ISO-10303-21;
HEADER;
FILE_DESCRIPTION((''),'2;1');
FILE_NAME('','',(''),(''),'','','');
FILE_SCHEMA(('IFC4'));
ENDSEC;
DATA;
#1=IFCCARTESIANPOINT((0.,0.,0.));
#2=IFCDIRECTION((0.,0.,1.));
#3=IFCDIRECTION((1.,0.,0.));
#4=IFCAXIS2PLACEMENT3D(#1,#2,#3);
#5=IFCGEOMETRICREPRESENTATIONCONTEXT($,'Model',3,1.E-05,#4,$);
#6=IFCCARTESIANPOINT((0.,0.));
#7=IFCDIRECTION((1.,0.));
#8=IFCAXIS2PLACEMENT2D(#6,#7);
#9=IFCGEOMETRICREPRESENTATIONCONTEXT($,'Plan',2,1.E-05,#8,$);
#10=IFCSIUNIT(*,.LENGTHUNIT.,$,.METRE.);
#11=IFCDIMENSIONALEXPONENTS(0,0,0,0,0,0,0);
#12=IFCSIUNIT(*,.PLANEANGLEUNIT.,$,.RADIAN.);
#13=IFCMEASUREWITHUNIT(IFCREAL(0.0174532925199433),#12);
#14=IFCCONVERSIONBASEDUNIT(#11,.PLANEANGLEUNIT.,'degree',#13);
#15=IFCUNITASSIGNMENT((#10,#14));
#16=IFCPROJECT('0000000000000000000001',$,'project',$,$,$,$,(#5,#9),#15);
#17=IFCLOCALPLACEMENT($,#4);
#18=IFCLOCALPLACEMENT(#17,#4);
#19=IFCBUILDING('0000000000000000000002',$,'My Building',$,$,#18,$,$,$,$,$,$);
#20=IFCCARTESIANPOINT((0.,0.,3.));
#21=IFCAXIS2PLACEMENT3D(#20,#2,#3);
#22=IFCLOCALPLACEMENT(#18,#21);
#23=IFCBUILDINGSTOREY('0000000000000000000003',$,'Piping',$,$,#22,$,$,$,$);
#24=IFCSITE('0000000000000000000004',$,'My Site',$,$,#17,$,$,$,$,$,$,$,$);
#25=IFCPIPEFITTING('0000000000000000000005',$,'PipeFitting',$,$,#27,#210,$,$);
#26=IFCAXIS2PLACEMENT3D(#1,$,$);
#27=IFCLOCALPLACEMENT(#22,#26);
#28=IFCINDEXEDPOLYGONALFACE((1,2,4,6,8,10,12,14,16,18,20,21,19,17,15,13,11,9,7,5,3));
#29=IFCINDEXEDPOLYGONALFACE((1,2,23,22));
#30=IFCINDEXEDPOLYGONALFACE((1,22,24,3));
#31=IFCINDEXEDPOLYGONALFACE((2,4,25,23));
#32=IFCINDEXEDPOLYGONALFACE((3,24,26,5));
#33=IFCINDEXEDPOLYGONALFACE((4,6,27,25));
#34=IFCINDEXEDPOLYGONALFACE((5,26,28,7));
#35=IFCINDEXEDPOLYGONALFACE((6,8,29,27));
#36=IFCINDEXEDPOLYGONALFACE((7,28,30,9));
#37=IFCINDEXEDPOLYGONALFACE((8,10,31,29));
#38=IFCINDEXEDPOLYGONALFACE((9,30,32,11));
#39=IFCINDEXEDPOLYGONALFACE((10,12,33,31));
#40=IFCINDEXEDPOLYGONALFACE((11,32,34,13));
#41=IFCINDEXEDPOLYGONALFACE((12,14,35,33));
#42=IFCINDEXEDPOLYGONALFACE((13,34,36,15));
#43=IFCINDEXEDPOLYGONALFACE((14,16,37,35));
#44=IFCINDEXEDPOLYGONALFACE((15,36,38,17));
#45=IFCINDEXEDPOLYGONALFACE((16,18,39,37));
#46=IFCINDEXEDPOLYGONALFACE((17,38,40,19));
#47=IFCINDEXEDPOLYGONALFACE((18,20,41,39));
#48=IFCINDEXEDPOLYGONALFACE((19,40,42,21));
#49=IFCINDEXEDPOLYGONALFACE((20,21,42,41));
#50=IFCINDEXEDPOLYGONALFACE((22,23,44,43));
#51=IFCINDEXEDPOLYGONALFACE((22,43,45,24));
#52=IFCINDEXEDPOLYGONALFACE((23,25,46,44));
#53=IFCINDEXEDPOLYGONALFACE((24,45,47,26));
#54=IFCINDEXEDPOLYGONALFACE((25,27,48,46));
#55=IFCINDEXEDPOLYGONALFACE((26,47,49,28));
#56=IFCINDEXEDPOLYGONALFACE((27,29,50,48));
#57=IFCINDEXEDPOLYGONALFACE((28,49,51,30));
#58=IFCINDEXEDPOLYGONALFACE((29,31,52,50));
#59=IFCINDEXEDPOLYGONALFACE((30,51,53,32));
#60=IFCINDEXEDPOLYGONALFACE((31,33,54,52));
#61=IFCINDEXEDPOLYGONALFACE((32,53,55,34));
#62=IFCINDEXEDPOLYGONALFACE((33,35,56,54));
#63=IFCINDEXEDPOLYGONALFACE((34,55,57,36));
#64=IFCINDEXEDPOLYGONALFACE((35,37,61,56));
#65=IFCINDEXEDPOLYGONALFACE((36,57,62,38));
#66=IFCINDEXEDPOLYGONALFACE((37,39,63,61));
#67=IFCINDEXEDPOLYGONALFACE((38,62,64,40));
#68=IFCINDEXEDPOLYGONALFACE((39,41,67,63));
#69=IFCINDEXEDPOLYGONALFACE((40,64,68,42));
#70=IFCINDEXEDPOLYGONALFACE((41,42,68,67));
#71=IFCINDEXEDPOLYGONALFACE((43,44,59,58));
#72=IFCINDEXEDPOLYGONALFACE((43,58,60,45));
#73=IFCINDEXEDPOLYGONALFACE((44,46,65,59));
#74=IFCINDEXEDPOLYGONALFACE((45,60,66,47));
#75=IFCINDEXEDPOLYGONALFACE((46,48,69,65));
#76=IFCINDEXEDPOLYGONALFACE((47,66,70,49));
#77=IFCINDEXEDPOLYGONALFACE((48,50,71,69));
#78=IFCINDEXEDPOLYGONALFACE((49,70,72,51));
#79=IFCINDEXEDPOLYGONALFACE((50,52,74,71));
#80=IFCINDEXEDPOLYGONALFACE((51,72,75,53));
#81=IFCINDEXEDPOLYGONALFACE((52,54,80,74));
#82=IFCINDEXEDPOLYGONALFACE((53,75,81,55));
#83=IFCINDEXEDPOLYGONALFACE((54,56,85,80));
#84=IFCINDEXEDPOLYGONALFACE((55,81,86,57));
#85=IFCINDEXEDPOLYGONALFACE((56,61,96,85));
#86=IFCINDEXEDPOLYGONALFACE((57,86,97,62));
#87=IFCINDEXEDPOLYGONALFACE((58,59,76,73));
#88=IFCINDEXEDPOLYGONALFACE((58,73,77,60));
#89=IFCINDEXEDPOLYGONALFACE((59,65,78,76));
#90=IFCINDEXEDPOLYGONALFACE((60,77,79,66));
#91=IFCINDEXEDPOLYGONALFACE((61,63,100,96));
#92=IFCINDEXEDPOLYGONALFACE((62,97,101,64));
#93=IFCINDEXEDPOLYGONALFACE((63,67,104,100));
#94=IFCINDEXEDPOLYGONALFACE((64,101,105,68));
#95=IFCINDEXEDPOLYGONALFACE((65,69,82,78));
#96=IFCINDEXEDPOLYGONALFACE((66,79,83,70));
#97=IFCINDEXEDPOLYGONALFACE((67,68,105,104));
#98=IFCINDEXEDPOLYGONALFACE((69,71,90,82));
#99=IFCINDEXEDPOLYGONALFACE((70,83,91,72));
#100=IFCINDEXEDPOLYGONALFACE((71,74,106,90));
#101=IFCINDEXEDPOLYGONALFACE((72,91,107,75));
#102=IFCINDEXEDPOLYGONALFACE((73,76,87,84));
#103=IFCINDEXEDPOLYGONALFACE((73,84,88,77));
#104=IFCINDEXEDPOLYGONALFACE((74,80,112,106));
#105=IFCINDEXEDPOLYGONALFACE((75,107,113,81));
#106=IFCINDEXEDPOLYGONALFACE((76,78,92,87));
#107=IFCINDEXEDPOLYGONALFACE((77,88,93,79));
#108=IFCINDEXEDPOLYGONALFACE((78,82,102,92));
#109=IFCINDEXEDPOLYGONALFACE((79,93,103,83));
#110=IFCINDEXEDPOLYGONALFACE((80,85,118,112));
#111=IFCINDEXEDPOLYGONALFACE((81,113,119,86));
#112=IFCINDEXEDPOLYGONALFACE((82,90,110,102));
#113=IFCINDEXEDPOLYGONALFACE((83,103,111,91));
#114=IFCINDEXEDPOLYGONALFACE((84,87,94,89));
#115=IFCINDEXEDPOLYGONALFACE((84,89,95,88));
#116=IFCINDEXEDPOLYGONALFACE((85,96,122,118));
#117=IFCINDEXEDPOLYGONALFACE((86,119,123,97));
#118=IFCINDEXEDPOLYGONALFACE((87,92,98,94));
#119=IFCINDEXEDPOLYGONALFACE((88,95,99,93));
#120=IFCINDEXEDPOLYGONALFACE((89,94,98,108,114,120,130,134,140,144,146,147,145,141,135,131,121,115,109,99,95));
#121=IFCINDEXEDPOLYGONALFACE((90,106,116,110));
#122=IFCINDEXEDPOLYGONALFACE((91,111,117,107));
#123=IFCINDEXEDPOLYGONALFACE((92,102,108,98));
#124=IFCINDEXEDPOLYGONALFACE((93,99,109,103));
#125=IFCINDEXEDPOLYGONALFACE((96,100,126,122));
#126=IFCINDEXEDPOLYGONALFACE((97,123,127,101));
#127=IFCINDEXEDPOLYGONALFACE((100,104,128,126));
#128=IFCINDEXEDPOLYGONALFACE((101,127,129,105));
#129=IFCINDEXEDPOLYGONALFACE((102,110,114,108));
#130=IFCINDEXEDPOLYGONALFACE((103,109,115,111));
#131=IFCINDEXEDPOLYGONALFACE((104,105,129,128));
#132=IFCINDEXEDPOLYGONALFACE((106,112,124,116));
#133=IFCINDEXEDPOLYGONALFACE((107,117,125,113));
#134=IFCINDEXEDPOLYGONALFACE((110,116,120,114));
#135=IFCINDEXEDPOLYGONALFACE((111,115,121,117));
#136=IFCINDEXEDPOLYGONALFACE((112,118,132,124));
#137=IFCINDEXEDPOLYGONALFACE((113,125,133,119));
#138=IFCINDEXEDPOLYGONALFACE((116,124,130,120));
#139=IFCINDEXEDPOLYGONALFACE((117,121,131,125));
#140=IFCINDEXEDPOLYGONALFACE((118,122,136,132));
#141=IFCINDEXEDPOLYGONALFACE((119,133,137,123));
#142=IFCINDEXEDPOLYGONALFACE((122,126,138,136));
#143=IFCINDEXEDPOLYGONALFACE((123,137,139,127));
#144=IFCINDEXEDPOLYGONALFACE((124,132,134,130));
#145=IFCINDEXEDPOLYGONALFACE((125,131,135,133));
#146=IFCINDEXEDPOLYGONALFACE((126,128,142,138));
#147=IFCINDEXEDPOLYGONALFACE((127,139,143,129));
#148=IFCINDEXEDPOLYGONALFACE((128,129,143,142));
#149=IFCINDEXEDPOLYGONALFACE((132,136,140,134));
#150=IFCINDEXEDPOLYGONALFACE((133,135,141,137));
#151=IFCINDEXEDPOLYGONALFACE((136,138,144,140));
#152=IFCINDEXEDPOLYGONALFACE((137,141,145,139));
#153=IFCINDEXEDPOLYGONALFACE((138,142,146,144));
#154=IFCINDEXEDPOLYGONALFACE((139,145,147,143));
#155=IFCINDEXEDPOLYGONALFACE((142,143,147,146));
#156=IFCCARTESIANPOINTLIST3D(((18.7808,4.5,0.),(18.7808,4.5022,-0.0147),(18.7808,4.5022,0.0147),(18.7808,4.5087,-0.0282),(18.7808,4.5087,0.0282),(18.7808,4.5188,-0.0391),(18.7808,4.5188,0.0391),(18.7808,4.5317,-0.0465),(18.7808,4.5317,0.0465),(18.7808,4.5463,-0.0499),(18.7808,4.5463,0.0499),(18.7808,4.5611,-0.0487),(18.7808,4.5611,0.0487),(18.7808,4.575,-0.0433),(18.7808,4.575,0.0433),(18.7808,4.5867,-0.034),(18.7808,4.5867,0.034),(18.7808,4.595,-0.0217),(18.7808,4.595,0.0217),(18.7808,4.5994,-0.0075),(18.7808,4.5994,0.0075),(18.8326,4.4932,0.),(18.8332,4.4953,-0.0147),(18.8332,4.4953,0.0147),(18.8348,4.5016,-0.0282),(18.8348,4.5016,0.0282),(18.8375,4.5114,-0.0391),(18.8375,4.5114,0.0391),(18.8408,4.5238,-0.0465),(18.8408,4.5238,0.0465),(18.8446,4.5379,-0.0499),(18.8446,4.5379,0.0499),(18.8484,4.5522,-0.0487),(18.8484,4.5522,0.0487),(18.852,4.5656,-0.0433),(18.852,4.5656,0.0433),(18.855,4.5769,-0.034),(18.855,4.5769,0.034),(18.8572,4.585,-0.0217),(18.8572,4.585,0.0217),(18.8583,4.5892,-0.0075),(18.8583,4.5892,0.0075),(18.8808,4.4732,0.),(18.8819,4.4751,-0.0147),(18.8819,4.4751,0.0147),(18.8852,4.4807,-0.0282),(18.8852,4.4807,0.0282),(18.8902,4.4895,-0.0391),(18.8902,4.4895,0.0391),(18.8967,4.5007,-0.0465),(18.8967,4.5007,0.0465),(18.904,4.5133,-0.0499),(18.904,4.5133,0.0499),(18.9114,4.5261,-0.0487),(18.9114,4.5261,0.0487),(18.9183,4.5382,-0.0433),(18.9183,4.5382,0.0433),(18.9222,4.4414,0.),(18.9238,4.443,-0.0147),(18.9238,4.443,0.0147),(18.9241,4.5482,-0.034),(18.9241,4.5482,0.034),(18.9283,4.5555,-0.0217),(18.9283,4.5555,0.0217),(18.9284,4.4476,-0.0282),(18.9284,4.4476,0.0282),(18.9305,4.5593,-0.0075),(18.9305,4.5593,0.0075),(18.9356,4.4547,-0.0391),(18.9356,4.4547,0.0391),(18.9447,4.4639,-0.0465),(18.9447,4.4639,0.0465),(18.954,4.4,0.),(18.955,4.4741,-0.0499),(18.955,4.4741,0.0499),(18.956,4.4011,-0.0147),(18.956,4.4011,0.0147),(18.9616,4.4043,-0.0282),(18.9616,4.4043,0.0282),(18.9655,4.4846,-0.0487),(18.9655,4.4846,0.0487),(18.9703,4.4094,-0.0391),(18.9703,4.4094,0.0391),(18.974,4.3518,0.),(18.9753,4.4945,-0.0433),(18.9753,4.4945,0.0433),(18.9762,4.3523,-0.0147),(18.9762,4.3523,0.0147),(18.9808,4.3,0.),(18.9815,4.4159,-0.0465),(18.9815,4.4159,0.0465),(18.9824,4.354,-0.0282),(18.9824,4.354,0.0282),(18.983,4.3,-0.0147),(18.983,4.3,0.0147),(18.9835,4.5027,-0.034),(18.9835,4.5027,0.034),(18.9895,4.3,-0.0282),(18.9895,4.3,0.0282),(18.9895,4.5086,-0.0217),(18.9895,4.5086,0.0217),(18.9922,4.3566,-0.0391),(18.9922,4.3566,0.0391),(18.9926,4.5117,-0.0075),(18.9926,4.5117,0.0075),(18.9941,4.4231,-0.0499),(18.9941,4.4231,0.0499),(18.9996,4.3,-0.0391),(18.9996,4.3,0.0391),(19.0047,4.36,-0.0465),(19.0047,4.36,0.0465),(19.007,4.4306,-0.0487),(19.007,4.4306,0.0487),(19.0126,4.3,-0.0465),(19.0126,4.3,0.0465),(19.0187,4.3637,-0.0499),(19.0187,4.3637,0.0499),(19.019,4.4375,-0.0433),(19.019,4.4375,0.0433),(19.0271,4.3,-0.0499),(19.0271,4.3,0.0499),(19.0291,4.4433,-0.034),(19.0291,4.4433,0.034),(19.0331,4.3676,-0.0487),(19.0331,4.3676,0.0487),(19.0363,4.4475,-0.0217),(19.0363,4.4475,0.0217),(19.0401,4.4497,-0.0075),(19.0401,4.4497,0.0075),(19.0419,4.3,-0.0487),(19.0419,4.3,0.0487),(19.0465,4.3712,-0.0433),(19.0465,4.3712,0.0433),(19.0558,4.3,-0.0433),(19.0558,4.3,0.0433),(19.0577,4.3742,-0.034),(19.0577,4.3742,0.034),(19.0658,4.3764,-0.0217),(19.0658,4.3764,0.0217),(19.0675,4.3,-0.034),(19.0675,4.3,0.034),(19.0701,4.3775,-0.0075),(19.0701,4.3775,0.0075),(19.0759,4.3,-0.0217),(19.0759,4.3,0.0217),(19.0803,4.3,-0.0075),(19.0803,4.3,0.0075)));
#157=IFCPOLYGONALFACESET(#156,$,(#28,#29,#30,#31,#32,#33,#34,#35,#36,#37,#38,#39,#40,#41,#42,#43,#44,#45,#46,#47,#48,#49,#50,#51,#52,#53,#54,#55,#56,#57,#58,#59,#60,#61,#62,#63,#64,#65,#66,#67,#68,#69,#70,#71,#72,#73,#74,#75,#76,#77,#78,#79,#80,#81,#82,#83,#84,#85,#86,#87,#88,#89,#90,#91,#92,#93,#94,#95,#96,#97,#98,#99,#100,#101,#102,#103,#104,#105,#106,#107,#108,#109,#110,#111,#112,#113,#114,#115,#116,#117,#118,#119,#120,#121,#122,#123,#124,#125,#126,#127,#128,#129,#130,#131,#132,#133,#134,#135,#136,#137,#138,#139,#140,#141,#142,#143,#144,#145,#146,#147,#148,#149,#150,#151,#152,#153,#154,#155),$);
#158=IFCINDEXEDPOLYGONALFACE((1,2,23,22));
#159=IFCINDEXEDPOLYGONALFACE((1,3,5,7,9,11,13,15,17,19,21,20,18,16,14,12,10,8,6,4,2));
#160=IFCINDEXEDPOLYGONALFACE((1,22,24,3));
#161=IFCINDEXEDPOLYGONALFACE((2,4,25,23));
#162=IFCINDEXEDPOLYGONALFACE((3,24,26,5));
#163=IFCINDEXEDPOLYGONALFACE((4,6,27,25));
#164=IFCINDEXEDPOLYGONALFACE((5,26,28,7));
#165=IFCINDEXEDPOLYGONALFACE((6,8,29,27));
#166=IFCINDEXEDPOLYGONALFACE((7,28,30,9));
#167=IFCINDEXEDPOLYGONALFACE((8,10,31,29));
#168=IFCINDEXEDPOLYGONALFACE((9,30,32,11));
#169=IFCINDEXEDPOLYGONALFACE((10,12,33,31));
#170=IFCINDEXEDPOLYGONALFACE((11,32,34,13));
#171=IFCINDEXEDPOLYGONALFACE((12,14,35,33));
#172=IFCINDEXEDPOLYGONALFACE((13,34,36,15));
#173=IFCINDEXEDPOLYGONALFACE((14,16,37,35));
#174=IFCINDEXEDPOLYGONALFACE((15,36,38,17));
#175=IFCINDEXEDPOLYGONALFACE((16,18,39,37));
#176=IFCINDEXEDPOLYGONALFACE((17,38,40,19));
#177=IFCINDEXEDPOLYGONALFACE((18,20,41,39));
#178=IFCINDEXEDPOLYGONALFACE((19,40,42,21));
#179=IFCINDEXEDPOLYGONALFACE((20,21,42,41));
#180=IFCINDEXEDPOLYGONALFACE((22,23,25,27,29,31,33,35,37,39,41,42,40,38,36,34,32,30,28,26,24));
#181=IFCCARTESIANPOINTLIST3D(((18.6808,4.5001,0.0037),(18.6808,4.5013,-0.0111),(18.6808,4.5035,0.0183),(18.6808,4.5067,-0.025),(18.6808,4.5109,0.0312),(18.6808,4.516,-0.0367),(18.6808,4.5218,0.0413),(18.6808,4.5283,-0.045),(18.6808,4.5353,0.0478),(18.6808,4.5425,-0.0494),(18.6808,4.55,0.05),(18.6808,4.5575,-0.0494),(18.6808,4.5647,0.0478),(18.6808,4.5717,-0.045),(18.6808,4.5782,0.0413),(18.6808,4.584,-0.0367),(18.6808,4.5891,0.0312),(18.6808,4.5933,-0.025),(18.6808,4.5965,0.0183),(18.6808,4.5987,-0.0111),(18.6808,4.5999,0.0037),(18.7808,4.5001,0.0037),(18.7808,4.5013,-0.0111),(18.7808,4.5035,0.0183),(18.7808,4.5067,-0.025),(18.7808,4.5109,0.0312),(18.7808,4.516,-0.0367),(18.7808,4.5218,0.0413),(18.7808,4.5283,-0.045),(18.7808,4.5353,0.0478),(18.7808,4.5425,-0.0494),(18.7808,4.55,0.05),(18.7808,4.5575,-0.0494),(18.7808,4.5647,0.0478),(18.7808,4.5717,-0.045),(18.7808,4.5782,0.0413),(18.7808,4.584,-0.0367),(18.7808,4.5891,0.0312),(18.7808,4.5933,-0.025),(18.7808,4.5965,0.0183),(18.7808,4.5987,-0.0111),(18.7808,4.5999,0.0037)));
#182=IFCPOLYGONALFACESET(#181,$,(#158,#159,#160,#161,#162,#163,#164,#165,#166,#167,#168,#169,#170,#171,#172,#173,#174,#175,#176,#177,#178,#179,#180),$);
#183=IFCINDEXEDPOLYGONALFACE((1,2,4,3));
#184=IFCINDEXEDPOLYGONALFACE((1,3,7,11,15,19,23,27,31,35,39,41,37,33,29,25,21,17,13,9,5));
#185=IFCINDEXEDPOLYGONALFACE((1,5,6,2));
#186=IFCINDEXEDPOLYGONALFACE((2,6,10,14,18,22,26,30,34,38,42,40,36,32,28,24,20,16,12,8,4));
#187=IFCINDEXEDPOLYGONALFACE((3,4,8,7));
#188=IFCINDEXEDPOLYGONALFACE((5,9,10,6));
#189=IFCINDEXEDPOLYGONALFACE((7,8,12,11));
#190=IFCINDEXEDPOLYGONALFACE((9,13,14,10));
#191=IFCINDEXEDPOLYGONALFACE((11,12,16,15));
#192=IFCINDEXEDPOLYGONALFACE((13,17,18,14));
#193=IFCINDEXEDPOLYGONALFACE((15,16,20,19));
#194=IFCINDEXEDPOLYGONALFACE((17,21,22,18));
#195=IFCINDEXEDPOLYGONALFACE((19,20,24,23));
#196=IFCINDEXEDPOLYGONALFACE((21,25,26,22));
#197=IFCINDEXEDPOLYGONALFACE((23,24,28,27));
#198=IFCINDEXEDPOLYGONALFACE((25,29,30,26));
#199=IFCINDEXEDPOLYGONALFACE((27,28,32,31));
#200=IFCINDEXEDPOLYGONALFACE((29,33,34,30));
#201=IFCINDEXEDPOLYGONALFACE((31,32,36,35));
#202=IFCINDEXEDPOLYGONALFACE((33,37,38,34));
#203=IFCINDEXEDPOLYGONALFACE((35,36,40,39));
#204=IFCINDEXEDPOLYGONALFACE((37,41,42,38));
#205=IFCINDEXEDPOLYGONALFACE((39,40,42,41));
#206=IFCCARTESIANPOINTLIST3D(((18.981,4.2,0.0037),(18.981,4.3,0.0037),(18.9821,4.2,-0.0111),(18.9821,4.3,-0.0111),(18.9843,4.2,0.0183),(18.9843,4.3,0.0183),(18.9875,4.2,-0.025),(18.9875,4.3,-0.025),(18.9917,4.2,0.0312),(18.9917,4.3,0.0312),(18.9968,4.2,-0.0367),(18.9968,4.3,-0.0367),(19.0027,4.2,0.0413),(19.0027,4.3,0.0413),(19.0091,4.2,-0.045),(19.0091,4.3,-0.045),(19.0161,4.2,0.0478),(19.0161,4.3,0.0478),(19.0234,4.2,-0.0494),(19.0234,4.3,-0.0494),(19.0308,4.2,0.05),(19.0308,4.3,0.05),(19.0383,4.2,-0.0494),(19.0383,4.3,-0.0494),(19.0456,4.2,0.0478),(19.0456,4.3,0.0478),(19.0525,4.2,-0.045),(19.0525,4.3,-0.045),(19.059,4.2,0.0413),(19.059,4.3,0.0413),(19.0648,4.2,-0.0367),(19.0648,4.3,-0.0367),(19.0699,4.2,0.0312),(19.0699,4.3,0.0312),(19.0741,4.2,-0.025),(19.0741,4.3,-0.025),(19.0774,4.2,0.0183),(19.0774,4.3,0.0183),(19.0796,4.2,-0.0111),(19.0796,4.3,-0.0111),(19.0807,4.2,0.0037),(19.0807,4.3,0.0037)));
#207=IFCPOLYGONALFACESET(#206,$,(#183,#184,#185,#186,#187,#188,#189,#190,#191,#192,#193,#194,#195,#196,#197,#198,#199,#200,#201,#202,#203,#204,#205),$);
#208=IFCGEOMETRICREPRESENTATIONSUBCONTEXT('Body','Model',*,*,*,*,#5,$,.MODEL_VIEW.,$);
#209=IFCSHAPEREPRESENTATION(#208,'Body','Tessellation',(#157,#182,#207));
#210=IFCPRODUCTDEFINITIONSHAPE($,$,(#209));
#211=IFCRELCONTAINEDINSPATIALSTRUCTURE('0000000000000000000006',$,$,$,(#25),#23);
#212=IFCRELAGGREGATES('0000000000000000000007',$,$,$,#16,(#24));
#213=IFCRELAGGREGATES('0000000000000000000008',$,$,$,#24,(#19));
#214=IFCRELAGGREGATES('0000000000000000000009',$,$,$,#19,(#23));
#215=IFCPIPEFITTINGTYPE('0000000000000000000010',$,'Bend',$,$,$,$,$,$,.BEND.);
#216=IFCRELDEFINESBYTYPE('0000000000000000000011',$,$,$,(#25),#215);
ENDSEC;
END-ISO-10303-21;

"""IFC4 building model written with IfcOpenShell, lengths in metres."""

from ifc_helpers import new_model, entity, si_unit, converted_unit, frame, origin_with_axes, origin_2d_with_axis, place, context, subcontext, project, spatial, circle, extrude, source, transform, mapped, type_object, type_shapes, element, save


model = new_model("IFC4")

# Units and contexts
model_context = context("Model", 3, precision=1e-05, world=origin_with_axes())
plan_context = context("Plan", 2, precision=1e-05, world=origin_2d_with_axis())
body_context = subcontext(model_context, "Body", "Model", "MODEL_VIEW")
ifc_project = project(units=[si_unit("LENGTHUNIT", "METRE"), converted_unit("PLANEANGLEUNIT", "degree", entity("IfcReal", 0.0174532925199433), si_unit("PLANEANGLEUNIT", "RADIAN"), dimensions=[0, 0, 0, 0, 0, 0, 0])], contexts=[model_context, plan_context])

# Site, building, storey
site_placement = place(None, origin_with_axes())
site = spatial("IfcSite", under=ifc_project, at=site_placement, Name="My Site")
building_placement = place(site_placement, origin_with_axes())
building = spatial("IfcBuilding", under=site, at=building_placement, Name="My Building")
storey_placement = place(building_placement, frame((0.0, 0.0, 3.0), z_axis=(0.0, 0.0, 1.0), x_axis=(1.0, 0.0, 0.0)))
storey = spatial("IfcBuildingStorey", under=building, at=storey_placement, Name="Piping")

# Pipe fitting
pipe_fitting_type = type_object("IfcPipeFittingType", Name="Bend", PredefinedType="BEND")
shared_shape = source(origin_with_axes(), body_context, "Body", "SolidModel", [
    entity("IfcSweptDiskSolid", entity("IfcIndexedPolyCurve", entity("IfcCartesianPointList3D", [[0.0, 0.0, -0.1], [0.0, -0.0732, -0.2768], [0.0, -0.25, -0.35]]), [entity("IfcArcIndex", [1, 2, 3])]), 0.05),
    extrude(circle(Radius=0.05), origin_with_axes(), (0.0, 0.0, -1.0), 0.1),
    extrude(circle(Radius=0.05), frame((0.0, -0.25, -0.35), z_axis=(0.0, -1.0, 0.0), x_axis=(1.0, 0.0, 0.0)), (0.0, 0.0, 1.0), 0.1),
])
type_shapes(pipe_fitting_type, [shared_shape])
for number, where, z_axis, x_axis, name in (
    (1, (18.6808, 4.55, 0.0), (-1.0, 0.0, 0.0), (0.0, 0.0, 1.0), "PipeFitting"),
):
    element("IfcPipeFitting", number, at=place(storey_placement, frame(where, z_axis=z_axis, x_axis=x_axis)), inside=storey, type_object=pipe_fitting_type, Name=name, context=body_context, shape_type="MappedRepresentation", body=[
        mapped(shared_shape, transform((0.0, 0.0, 0.0), x_axis=(1.0, 0.0, 0.0), y_axis=(0.0, 1.0, 0.0), z_axis=(0.0, 0.0, 1.0), scale=1.0)),
    ])

save(model, "model.ifc")
